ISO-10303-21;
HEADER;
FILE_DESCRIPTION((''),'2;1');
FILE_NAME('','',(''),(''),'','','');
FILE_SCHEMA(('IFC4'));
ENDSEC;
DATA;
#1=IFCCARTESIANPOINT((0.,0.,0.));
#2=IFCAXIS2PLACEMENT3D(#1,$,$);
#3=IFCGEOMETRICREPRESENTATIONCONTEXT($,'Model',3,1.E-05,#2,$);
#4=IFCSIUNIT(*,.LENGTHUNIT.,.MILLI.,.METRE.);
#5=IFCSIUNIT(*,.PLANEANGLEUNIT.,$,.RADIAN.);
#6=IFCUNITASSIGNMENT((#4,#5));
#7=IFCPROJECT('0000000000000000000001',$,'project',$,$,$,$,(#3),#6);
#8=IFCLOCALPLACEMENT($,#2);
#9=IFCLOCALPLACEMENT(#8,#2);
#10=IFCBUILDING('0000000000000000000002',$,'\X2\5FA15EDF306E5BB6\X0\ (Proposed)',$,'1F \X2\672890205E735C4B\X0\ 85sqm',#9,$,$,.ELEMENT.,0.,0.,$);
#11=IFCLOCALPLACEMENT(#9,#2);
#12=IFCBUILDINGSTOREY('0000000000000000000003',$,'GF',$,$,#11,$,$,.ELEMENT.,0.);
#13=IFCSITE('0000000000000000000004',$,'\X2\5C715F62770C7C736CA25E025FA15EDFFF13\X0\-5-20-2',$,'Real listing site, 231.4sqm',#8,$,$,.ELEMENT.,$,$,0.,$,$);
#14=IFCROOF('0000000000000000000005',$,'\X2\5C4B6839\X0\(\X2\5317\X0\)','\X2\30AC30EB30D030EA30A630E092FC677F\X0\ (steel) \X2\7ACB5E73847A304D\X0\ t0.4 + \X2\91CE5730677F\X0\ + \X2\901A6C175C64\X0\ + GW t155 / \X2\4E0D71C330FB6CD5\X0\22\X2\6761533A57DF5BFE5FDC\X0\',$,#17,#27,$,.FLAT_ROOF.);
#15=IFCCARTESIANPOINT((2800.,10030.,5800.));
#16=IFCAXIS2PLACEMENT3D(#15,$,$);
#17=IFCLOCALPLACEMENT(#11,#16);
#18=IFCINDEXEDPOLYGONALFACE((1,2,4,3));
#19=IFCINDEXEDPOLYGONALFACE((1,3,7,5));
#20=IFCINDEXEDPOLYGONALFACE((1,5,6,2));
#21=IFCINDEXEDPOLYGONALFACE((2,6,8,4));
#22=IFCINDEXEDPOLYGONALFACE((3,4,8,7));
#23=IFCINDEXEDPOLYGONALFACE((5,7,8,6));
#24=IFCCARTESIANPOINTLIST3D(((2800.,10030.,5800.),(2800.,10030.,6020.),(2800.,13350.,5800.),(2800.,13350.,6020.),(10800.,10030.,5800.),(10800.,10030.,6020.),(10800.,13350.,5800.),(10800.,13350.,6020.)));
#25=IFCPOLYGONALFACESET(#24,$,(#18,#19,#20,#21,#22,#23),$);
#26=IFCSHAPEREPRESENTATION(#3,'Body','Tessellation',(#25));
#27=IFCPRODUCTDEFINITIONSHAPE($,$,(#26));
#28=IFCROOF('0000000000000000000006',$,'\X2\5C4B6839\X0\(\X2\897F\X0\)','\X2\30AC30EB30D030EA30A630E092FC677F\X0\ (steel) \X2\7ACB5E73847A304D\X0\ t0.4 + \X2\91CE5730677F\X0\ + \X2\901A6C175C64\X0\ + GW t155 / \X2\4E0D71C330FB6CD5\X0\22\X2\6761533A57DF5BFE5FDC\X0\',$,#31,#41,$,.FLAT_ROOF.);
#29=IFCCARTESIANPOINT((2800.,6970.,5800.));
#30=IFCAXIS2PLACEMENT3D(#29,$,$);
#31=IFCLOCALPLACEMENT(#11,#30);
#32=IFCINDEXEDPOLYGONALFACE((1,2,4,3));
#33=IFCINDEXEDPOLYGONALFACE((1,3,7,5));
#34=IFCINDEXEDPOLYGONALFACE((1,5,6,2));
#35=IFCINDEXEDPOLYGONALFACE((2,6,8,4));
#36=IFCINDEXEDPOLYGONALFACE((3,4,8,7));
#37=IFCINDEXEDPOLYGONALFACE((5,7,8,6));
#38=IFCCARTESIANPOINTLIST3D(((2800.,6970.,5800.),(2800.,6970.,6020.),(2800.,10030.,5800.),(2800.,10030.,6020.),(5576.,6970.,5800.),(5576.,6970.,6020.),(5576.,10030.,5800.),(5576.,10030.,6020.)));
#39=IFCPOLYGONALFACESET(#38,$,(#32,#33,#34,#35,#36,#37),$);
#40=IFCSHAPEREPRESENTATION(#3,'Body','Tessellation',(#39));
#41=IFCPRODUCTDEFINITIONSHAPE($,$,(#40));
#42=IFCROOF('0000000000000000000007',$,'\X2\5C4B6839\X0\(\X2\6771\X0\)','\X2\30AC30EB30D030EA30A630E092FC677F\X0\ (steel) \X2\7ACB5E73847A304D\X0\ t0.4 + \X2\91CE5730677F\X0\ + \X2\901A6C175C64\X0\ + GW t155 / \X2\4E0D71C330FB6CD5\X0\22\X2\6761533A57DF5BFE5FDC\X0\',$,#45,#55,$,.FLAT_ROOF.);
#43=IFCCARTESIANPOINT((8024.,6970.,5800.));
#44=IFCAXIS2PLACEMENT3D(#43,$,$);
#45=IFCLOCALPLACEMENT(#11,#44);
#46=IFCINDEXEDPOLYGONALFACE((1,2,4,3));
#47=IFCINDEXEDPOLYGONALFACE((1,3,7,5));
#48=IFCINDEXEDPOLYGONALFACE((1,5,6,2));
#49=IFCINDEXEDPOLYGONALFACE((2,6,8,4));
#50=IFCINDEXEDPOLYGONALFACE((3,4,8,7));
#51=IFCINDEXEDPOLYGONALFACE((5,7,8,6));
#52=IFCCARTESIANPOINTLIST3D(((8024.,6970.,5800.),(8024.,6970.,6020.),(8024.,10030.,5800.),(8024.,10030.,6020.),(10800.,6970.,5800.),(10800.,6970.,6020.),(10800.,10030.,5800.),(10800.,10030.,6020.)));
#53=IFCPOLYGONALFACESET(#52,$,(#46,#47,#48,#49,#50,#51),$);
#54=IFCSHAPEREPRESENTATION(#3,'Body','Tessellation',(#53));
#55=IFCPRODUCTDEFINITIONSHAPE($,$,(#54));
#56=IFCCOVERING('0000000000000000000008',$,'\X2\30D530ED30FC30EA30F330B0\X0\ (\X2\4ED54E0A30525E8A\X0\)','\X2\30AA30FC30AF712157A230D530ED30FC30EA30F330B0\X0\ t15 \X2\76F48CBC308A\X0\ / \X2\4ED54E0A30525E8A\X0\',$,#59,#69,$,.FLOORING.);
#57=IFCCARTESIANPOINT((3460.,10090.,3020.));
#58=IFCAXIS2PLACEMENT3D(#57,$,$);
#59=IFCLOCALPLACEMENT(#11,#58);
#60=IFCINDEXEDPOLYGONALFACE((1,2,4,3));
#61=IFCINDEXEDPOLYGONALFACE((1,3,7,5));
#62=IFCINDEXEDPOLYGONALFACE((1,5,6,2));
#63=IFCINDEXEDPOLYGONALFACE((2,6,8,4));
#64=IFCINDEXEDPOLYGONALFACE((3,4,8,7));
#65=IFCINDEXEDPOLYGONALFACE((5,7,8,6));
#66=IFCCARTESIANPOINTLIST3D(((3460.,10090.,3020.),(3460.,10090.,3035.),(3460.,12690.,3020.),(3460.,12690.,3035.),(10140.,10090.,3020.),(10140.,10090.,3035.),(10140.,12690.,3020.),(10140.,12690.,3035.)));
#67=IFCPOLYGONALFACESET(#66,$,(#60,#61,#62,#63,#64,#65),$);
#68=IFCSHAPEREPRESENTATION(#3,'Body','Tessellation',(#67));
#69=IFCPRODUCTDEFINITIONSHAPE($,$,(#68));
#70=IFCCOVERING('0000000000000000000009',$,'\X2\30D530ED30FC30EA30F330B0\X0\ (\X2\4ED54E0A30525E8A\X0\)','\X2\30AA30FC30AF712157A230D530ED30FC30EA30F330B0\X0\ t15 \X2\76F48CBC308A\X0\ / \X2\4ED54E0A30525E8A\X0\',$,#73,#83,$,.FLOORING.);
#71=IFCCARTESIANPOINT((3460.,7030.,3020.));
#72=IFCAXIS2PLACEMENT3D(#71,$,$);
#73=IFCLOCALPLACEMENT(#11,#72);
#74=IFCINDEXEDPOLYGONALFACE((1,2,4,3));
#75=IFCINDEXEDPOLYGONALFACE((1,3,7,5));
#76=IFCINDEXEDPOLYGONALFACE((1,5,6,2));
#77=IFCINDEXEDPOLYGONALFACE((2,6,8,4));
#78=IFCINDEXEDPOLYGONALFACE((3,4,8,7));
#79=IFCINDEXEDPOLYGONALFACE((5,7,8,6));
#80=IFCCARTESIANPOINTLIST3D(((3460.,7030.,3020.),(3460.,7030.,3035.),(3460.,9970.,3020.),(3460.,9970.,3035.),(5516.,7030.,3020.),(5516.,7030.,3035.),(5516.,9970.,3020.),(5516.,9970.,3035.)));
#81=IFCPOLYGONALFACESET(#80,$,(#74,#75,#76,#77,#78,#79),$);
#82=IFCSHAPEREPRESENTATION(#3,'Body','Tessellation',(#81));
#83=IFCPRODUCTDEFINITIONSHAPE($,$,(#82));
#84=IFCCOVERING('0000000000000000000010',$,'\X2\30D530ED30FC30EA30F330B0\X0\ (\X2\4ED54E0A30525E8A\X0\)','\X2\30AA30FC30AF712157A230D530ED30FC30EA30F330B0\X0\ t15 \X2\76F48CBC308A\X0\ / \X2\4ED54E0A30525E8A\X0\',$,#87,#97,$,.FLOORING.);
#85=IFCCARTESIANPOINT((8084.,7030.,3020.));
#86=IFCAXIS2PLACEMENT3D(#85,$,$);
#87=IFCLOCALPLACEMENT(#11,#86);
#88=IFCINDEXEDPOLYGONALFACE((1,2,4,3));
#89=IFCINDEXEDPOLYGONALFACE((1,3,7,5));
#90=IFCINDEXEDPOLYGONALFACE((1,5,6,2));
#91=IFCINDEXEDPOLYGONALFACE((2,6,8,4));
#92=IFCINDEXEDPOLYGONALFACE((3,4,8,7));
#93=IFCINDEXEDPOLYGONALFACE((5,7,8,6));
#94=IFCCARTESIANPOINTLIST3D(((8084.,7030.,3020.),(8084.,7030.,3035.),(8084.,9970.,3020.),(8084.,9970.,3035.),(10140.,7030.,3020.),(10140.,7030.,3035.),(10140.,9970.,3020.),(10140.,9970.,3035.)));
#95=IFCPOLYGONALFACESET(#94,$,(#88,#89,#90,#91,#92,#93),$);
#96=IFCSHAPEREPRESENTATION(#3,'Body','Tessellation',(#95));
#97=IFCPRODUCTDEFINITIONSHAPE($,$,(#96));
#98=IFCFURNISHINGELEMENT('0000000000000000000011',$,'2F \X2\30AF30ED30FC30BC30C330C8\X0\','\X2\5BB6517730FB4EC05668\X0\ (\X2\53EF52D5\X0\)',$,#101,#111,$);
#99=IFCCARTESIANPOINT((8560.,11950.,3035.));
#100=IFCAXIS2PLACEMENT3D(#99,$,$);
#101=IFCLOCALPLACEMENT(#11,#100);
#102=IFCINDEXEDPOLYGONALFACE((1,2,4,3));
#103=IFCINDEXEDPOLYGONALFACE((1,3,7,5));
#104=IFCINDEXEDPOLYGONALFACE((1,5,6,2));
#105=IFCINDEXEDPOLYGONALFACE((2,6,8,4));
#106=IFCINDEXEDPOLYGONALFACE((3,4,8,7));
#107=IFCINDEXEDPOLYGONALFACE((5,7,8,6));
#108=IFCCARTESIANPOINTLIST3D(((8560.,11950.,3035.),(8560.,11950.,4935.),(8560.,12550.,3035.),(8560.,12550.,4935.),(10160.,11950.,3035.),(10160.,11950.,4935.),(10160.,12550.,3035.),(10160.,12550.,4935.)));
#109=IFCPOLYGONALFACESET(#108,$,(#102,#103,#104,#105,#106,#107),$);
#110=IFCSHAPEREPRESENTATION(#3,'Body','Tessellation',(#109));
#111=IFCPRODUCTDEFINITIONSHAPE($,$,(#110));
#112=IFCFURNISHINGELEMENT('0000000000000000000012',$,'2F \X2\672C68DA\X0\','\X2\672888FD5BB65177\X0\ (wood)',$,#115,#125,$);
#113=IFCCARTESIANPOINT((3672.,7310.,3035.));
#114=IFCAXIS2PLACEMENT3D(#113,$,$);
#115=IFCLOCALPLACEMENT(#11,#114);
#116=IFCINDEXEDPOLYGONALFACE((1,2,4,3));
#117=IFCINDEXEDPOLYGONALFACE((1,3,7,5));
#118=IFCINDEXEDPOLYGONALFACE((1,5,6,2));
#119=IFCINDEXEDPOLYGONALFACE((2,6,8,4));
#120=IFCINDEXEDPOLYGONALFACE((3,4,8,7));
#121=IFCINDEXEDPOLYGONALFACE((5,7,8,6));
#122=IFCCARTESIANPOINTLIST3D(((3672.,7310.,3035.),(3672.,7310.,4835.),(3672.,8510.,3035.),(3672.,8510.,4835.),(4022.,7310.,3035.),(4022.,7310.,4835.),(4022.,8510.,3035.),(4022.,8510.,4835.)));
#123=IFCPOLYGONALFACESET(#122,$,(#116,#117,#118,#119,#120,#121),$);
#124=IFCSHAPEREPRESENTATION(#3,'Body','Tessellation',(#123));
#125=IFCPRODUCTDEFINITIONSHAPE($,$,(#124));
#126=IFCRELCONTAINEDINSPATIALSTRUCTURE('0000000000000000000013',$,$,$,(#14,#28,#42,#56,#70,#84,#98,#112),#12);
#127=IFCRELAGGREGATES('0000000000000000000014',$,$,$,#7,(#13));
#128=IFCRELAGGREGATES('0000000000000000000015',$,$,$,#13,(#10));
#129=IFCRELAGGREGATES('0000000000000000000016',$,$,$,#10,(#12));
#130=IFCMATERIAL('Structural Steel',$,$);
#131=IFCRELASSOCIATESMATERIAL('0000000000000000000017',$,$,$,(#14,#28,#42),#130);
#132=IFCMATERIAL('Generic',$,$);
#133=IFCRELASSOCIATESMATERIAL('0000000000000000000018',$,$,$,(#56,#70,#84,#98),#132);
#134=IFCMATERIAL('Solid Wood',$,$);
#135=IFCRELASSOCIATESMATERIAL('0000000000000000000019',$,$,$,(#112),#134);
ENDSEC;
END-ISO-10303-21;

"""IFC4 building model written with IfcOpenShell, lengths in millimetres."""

from ifc_helpers import new_model, si_unit, frame, frame_2d, origin, place, context, project, spatial, rectangle, extrude, material, element, save


model = new_model("IFC4")

# Units and contexts
model_context = context("Model", 3, precision=1e-05, world=origin())
ifc_project = project(units=[si_unit("LENGTHUNIT", "METRE", prefix="MILLI"), si_unit("PLANEANGLEUNIT", "RADIAN")], contexts=[model_context])

# Site, building, storey
site_placement = place(None, origin())
site = spatial("IfcSite", under=ifc_project, at=site_placement, Name="山形県米沢市御廟３-5-20-2", ObjectType="Real listing site, 231.4sqm", CompositionType="ELEMENT", RefElevation=0.0)
building_placement = place(site_placement, origin())
building = spatial("IfcBuilding", under=site, at=building_placement, Name="御廟の家 (Proposed)", ObjectType="1F 木造平屋 85sqm", CompositionType="ELEMENT", ElevationOfRefHeight=0.0, ElevationOfTerrain=0.0)
storey_placement = place(building_placement, origin())
storey = spatial("IfcBuildingStorey", under=building, at=storey_placement, Name="GF", CompositionType="ELEMENT", Elevation=0.0)

# Shared definitions
ifc_material_1 = material(Name="Solid Wood")

# Shared definitions
ifc_material_2 = material(Name="Generic")

# Roofs
ifc_material_3 = material(Name="Structural Steel")
for number, where, name in (
    (1, (2800.0, 10030.0, 5800.0), "屋根(北)"),
):
    element("IfcRoof", number, at=place(storey_placement, frame(where)), inside=storey, material=ifc_material_3, Name=name, Description="ガルバリウム鋼板 (steel) 立平葺き t0.4 + 野地板 + 通気層 + GW t155 / 不燃・法22条区域対応", PredefinedType="FLAT_ROOF", context=model_context, shape_type="SweptSolid", body=[
        extrude(rectangle(XDim=8000.0, YDim=3320.0, at=frame_2d((4000.0, 1660.0))), frame((2800.0, 10030.0, 5800.0)), (0.0, 0.0, 1.0), 220.0),
    ])
roof_1_placement = place(storey_placement, frame((2800.0, 6970.0, 5800.0)))
element("IfcRoof", 2, at=roof_1_placement, inside=storey, material=ifc_material_3, Name="屋根(西)", Description="ガルバリウム鋼板 (steel) 立平葺き t0.4 + 野地板 + 通気層 + GW t155 / 不燃・法22条区域対応", PredefinedType="FLAT_ROOF", context=model_context, shape_type="SweptSolid", body=[
    extrude(rectangle(XDim=2776.0, YDim=3060.0, at=frame_2d((1388.0, 1530.0))), frame((2800.0, 6970.0, 5800.0)), (0.0, 0.0, 1.0), 220.0),
])
roof_2_placement = place(storey_placement, frame((8024.0, 6970.0, 5800.0)))
element("IfcRoof", 3, at=roof_2_placement, inside=storey, material=ifc_material_3, Name="屋根(東)", Description="ガルバリウム鋼板 (steel) 立平葺き t0.4 + 野地板 + 通気層 + GW t155 / 不燃・法22条区域対応", PredefinedType="FLAT_ROOF", context=model_context, shape_type="SweptSolid", body=[
    extrude(rectangle(XDim=2776.0, YDim=3060.0, at=frame_2d((1388.0, 1530.0))), frame((8024.0, 6970.0, 5800.0)), (0.0, 0.0, 1.0), 220.0),
])

# Coverings
covering_1_placement = place(storey_placement, frame((3460.0, 10090.0, 3020.0)))
element("IfcCovering", 4, at=covering_1_placement, inside=storey, material=ifc_material_2, Name="フローリング (仕上げ床)", Description="オーク無垢フローリング t15 直貼り / 仕上げ床", PredefinedType="FLOORING", context=model_context, shape_type="SweptSolid", body=[
    extrude(rectangle(XDim=6680.0, YDim=2600.0, at=frame_2d((3340.0, 1300.0))), frame((3460.0, 10090.0, 3020.0)), (0.0, 0.0, 1.0), 15.0),
])
covering_2_placement = place(storey_placement, frame((3460.0, 7030.0, 3020.0)))
element("IfcCovering", 5, at=covering_2_placement, inside=storey, material=ifc_material_2, Name="フローリング (仕上げ床)", Description="オーク無垢フローリング t15 直貼り / 仕上げ床", PredefinedType="FLOORING", context=model_context, shape_type="SweptSolid", body=[
    extrude(rectangle(XDim=2056.0, YDim=2940.0, at=frame_2d((1028.0, 1470.0))), frame((3460.0, 7030.0, 3020.0)), (0.0, 0.0, 1.0), 15.0),
])
covering_3_placement = place(storey_placement, frame((8084.0, 7030.0, 3020.0)))
element("IfcCovering", 6, at=covering_3_placement, inside=storey, material=ifc_material_2, Name="フローリング (仕上げ床)", Description="オーク無垢フローリング t15 直貼り / 仕上げ床", PredefinedType="FLOORING", context=model_context, shape_type="SweptSolid", body=[
    extrude(rectangle(XDim=2056.0, YDim=2940.0, at=frame_2d((1028.0, 1470.0))), frame((8084.0, 7030.0, 3020.0)), (0.0, 0.0, 1.0), 15.0),
])

# Furnishing elements
furnishing_1_placement = place(storey_placement, frame((8560.0, 11950.0, 3035.0)))
element("IfcFurnishingElement", 7, at=furnishing_1_placement, inside=storey, material=ifc_material_2, Name="2F クローゼット", Description="家具・什器 (可動)", context=model_context, shape_type="SweptSolid", body=[
    extrude(rectangle(XDim=1600.0, YDim=600.0, at=frame_2d((800.0, 300.0))), frame((8560.0, 11950.0, 3035.0)), (0.0, 0.0, 1.0), 1900.0),
])
furnishing_2_placement = place(storey_placement, frame((3672.0, 7310.0, 3035.0)))
element("IfcFurnishingElement", 8, at=furnishing_2_placement, inside=storey, material=ifc_material_1, Name="2F 本棚", Description="木製家具 (wood)", context=model_context, shape_type="SweptSolid", body=[
    extrude(rectangle(XDim=350.0, YDim=1200.0, at=frame_2d((175.0, 600.0))), frame((3672.0, 7310.0, 3035.0)), (0.0, 0.0, 1.0), 1800.0),
])

save(model, "model.ifc")
